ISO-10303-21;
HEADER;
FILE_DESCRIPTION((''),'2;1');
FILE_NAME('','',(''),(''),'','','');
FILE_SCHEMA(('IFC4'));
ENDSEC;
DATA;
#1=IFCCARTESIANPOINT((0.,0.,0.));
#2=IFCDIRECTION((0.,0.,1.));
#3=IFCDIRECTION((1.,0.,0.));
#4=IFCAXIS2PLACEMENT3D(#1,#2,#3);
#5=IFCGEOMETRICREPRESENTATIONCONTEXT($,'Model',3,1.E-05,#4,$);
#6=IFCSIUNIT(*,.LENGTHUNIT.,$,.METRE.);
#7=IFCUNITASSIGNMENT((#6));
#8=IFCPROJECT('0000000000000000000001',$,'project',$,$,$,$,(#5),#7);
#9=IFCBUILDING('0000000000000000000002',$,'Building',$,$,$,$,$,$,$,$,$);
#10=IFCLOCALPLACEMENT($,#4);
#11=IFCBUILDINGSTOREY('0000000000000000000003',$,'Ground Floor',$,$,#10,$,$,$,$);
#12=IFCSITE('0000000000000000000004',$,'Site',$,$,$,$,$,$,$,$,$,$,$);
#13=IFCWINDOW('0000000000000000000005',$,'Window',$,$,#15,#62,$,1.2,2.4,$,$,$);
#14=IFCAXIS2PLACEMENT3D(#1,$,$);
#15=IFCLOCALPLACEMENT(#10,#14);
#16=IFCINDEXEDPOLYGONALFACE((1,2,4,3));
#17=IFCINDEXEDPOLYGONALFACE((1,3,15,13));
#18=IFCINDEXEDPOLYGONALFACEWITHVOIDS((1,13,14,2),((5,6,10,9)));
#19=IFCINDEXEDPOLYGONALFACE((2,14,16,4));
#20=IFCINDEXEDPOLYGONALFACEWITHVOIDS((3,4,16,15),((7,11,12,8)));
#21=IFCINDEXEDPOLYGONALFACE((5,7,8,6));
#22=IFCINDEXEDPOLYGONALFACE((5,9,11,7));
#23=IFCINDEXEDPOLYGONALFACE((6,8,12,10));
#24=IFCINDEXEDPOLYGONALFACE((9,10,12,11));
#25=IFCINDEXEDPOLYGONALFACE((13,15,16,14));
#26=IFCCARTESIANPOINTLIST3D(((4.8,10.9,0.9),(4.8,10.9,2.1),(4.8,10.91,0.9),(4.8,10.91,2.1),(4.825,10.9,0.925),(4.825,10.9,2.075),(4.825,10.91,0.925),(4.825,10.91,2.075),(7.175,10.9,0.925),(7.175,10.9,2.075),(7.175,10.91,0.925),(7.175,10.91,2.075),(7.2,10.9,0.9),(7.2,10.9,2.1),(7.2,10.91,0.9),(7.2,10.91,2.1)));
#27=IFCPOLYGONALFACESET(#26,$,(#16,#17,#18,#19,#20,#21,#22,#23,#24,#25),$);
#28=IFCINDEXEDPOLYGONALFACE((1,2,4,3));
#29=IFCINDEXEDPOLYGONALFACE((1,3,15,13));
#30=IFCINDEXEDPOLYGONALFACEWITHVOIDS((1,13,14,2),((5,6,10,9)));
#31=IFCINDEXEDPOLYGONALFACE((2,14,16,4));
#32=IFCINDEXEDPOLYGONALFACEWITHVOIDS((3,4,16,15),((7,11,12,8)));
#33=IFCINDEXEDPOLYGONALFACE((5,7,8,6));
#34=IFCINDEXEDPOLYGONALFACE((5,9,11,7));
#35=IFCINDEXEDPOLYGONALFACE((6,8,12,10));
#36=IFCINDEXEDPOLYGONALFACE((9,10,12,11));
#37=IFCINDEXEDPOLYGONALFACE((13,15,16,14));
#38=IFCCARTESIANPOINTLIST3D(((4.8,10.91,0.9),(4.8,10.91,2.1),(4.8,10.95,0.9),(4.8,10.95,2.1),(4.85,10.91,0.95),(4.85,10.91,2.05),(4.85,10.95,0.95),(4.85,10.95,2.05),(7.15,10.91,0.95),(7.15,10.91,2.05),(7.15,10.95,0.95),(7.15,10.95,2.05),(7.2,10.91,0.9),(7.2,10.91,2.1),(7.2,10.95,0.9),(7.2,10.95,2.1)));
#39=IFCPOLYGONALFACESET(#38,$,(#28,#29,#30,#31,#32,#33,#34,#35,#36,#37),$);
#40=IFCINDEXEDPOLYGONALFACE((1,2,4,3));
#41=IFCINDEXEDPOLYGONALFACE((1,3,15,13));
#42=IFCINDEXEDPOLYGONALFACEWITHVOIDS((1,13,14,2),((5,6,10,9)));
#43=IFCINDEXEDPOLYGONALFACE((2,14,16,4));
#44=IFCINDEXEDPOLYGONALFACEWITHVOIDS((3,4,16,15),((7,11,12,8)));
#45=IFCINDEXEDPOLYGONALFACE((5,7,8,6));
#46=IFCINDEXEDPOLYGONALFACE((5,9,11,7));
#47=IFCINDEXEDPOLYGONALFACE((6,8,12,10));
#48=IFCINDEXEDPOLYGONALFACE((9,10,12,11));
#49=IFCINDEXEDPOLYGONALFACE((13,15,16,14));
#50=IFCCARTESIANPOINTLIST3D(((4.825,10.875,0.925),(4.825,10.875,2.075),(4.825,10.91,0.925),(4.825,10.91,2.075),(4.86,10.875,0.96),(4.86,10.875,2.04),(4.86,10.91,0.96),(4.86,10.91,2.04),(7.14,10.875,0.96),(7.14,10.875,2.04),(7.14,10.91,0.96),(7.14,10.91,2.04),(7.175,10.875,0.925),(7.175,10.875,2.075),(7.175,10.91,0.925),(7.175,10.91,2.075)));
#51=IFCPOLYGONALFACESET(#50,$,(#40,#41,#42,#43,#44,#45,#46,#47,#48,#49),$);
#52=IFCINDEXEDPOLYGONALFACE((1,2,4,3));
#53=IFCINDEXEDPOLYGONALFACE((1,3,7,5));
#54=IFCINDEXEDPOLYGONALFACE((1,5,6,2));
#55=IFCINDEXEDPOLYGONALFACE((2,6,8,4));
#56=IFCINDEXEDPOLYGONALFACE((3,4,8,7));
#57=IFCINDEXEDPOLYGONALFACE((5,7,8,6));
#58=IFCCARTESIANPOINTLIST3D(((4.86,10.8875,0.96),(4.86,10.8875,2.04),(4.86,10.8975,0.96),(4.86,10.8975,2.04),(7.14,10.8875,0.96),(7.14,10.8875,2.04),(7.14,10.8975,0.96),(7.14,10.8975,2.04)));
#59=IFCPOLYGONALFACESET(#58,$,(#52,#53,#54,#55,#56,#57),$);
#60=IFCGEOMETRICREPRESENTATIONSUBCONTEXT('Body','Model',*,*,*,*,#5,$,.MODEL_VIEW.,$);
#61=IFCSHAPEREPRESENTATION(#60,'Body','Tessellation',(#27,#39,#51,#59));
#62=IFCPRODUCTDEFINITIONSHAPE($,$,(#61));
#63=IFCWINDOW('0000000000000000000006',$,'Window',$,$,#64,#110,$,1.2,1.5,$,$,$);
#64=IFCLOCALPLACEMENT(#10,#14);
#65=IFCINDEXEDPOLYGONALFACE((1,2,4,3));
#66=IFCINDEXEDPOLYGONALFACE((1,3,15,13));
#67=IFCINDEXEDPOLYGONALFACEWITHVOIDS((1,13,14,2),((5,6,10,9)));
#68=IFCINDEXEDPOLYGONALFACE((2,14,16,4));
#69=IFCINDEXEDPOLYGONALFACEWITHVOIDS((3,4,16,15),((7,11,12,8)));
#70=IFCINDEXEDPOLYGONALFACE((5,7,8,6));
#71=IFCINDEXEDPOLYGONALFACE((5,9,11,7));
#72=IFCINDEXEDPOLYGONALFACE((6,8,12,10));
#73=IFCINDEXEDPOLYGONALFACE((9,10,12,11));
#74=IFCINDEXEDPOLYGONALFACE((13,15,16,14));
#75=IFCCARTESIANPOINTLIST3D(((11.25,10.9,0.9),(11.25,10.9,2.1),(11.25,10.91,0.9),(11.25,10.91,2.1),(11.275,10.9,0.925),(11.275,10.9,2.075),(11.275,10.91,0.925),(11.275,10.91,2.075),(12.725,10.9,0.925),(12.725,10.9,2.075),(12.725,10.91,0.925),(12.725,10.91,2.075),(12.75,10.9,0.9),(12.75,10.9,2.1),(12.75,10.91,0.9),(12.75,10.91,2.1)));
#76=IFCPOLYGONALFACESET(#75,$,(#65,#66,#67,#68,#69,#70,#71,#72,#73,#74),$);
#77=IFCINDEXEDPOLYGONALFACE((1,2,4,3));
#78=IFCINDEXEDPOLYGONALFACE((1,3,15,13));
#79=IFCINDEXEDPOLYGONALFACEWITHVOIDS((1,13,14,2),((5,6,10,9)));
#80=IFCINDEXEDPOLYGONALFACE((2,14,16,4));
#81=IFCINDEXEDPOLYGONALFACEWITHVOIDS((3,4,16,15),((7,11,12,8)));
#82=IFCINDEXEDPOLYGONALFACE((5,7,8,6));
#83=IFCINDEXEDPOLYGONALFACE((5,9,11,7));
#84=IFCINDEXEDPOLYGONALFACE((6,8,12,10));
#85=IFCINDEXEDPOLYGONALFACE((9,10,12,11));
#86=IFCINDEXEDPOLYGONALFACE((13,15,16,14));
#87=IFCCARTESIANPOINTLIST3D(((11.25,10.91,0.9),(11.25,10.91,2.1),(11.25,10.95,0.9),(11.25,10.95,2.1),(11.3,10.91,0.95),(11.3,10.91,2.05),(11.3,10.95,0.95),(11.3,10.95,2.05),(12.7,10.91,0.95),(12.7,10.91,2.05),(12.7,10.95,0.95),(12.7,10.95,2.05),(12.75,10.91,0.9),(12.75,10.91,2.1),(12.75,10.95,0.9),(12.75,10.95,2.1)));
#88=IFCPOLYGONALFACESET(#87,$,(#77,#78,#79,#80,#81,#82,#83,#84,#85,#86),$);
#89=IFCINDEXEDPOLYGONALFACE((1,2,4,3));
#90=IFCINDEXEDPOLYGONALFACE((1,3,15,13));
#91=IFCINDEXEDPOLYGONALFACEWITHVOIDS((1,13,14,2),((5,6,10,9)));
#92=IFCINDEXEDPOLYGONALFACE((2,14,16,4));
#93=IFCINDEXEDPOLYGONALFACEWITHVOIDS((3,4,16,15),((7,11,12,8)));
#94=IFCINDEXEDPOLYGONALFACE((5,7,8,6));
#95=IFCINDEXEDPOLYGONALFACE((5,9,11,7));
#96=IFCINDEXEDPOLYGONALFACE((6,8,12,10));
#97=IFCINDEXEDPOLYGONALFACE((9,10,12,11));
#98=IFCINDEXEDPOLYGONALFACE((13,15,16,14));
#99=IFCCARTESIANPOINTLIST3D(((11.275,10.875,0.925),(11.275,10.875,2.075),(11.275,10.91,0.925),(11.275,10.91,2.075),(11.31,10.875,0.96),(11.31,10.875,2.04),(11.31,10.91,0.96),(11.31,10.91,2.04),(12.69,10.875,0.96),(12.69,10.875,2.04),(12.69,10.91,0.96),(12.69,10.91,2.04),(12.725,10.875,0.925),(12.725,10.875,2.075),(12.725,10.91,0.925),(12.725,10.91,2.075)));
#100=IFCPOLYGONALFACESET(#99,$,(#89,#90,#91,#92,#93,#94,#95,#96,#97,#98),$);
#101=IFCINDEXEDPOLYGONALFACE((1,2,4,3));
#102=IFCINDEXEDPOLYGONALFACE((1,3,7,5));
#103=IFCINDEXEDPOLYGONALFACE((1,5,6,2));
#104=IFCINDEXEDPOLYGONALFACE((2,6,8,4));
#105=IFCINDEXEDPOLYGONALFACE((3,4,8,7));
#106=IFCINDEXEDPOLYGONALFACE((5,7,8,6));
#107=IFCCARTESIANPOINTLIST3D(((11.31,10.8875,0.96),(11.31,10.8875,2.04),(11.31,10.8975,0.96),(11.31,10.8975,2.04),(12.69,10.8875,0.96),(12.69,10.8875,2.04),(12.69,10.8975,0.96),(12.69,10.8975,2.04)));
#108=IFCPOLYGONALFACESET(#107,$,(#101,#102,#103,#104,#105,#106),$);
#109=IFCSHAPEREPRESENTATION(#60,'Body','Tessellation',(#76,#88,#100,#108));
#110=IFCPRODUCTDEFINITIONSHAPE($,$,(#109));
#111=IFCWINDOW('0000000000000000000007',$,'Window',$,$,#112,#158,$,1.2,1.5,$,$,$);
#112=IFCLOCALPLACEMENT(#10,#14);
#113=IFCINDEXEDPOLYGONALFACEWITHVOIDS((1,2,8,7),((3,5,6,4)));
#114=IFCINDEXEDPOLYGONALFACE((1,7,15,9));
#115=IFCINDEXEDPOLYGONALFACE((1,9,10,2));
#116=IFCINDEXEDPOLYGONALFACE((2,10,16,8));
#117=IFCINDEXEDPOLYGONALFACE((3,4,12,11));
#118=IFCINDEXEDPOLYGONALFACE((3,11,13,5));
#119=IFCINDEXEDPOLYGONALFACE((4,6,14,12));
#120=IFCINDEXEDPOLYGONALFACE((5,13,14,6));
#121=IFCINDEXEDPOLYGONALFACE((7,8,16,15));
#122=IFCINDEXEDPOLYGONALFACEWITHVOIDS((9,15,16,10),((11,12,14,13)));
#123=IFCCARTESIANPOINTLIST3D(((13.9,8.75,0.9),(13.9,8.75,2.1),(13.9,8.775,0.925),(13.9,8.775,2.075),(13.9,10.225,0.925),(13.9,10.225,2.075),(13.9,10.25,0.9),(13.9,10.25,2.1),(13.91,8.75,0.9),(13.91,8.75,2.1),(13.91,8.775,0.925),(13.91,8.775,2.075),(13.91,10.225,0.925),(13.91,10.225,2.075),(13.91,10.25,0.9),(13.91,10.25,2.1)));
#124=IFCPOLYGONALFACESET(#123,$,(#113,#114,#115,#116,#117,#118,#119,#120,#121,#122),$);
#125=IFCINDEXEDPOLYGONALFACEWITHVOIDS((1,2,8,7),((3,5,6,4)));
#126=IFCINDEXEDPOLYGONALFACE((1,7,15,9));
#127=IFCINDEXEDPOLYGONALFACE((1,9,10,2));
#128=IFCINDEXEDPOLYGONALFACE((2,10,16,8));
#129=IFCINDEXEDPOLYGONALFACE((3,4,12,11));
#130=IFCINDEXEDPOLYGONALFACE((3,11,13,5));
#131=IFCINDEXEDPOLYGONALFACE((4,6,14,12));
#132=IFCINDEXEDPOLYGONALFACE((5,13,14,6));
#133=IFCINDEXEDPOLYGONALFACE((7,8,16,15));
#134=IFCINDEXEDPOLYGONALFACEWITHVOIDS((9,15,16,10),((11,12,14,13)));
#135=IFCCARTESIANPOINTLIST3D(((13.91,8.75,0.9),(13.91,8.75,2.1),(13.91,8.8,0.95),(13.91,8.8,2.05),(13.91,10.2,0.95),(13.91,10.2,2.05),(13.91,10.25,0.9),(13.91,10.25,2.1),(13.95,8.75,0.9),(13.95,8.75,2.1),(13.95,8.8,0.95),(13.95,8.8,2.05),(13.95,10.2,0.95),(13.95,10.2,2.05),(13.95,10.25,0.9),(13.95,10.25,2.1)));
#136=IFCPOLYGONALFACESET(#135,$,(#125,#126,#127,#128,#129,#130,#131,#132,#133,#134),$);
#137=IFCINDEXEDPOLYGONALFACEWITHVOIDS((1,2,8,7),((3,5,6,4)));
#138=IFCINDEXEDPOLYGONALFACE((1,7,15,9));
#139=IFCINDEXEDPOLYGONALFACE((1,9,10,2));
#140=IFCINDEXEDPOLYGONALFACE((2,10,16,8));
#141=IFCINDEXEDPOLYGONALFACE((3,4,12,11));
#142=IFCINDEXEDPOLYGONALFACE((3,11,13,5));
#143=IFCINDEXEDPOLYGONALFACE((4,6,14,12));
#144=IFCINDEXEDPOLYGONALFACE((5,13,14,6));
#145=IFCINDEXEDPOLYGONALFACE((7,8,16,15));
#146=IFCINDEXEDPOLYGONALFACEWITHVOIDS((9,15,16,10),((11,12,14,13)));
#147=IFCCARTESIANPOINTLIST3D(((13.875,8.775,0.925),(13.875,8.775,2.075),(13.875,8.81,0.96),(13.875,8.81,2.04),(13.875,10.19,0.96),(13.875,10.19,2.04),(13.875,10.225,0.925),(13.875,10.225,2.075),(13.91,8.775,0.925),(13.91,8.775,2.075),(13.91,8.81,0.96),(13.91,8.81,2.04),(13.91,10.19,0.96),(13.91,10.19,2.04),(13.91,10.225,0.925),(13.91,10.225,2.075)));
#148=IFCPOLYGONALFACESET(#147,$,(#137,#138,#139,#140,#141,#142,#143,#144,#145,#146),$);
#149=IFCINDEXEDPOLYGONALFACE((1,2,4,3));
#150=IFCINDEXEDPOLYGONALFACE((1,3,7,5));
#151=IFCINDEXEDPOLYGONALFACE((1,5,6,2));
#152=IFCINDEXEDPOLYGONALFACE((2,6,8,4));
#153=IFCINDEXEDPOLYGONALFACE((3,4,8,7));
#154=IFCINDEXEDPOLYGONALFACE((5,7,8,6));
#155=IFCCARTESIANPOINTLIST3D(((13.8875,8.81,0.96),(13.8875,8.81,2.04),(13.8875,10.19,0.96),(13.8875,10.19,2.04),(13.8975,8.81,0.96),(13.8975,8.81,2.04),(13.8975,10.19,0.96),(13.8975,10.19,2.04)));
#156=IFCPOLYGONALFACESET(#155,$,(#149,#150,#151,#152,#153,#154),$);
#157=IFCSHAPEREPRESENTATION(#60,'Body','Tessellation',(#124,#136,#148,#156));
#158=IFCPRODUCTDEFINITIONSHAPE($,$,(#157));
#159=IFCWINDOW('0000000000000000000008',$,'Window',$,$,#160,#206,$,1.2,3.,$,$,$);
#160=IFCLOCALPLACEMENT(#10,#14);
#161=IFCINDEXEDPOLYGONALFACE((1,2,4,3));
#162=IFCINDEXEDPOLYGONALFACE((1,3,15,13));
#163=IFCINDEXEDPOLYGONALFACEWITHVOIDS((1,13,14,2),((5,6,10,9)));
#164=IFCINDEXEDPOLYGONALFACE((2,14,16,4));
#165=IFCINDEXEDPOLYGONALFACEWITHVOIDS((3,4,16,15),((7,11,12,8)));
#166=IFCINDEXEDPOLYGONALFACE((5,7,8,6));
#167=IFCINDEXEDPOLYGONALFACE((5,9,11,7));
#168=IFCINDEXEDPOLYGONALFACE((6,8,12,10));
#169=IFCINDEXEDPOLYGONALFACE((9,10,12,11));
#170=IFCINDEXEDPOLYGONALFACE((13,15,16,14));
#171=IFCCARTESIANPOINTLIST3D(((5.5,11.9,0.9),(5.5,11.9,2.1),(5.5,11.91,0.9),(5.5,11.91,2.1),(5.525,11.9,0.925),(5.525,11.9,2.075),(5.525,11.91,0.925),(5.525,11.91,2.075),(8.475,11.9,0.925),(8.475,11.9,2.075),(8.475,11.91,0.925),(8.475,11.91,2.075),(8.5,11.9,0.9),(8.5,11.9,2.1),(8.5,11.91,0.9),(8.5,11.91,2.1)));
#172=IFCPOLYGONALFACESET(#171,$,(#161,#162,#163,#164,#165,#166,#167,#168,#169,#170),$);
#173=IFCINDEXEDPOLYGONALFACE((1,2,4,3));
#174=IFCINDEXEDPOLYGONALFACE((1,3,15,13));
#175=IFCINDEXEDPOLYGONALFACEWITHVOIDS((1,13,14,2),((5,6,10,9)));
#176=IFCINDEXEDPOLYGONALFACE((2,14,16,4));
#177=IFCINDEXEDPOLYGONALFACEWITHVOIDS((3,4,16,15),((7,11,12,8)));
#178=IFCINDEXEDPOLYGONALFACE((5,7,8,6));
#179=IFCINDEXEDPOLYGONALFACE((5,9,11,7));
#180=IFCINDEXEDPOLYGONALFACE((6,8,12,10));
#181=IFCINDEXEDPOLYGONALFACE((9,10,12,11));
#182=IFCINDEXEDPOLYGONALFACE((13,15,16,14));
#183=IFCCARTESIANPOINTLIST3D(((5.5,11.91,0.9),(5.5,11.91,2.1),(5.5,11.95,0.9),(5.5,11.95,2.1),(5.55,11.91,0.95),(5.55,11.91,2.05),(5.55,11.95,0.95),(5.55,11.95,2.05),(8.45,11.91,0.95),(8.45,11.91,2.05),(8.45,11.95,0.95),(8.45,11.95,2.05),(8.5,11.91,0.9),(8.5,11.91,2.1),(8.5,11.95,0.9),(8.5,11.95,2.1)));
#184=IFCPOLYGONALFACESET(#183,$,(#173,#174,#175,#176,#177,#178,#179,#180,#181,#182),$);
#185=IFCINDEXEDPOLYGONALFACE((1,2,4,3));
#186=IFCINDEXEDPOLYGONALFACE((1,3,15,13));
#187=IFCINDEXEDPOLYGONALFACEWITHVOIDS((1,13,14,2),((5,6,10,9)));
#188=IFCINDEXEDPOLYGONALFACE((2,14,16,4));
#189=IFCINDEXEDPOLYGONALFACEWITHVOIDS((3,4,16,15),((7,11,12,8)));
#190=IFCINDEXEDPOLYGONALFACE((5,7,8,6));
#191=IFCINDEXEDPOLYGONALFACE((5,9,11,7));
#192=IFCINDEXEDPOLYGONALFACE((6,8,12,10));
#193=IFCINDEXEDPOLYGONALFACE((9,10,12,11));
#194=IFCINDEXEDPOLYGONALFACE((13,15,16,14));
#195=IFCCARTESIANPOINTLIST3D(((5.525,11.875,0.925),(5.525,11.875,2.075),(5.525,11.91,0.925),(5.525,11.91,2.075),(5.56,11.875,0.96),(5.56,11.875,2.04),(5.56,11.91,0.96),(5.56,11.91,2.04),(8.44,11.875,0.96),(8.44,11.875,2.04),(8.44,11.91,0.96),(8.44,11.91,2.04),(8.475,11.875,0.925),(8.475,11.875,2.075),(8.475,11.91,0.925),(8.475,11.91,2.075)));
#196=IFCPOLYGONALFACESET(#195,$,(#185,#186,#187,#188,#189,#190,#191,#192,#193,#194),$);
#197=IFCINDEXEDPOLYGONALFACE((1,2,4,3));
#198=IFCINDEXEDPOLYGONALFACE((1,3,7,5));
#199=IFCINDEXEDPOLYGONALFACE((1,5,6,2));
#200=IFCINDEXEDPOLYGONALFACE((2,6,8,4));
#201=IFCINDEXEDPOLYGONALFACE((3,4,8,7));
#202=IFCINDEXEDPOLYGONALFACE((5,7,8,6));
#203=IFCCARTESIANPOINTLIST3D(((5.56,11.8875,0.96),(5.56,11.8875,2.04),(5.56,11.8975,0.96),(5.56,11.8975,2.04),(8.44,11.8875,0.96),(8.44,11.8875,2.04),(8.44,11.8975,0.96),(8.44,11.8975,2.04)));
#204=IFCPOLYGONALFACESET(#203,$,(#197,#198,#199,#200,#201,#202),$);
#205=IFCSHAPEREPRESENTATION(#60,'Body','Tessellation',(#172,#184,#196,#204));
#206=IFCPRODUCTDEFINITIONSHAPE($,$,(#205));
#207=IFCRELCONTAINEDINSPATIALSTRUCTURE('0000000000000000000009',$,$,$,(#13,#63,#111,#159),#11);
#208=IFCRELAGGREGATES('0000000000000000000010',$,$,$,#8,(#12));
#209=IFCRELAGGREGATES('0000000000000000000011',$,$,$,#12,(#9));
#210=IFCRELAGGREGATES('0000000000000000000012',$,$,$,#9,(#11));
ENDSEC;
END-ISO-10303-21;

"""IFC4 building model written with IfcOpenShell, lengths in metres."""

from ifc_helpers import new_model, si_unit, frame, origin_with_axes, place, context, subcontext, project, spatial, line, indexed_curve, outline, extrude, element, save


model = new_model("IFC4")

# Units and contexts
model_context = context("Model", 3, precision=1e-05, world=origin_with_axes())
body_context = subcontext(model_context, "Body", "Model", "MODEL_VIEW")
ifc_project = project(units=[si_unit("LENGTHUNIT", "METRE")], contexts=[model_context])

# Site, building, storey
site = spatial("IfcSite", under=ifc_project, Name="Site")
building = spatial("IfcBuilding", under=site, Name="Building")
storey_placement = place(None, origin_with_axes())
storey = spatial("IfcBuildingStorey", under=building, at=storey_placement, Name="Ground Floor")

# Windows
window_1_placement = place(storey_placement, frame((7.2, 11.0, 0.9), z_axis=(0.0, 0.0, 1.0), x_axis=(-1.0, 0.0, 0.0)))
element("IfcWindow", 1, at=window_1_placement, inside=storey, Name="Window", OverallHeight=1.2, OverallWidth=2.4, context=body_context, shape_type="SweptSolid", body=[
    extrude(outline(indexed_curve([(0.0, 0.0), (2.4, 0.0), (2.4, 1.2), (0.0, 1.2)], segments=[line(1, 2, 3, 4, 1)]), holes=[indexed_curve([(0.025, 0.025), (2.375, 0.025), (2.375, 1.175), (0.025, 1.175)], segments=[line(1, 2, 3, 4, 1)])]), frame((0.0, 0.09, 0.0), z_axis=(0.0, -1.0, 0.0), x_axis=(1.0, 0.0, 0.0)), (0.0, 0.0, -1.0), 0.01),
    extrude(outline(indexed_curve([(0.0, 0.0), (2.4, 0.0), (2.4, 1.2), (0.0, 1.2)], segments=[line(1, 2, 3, 4, 1)]), holes=[indexed_curve([(0.05, 0.05), (2.35, 0.05), (2.35, 1.15), (0.05, 1.15)], segments=[line(1, 2, 3, 4, 1)])]), frame((0.0, 0.05, 0.0), z_axis=(0.0, -1.0, 0.0), x_axis=(1.0, 0.0, 0.0)), (0.0, 0.0, -1.0), 0.04),
    extrude(outline(indexed_curve([(0.0, 0.0), (2.35, 0.0), (2.35, 1.15), (0.0, 1.15)], segments=[line(1, 2, 3, 4, 1)]), holes=[indexed_curve([(0.035, 0.035), (2.315, 0.035), (2.315, 1.115), (0.035, 1.115)], segments=[line(1, 2, 3, 4, 1)])]), frame((0.025, 0.09, 0.025), z_axis=(0.0, -1.0, 0.0), x_axis=(1.0, 0.0, 0.0)), (0.0, 0.0, -1.0), 0.035),
    extrude(outline(indexed_curve([(0.035, 0.035), (2.315, 0.035), (2.315, 1.115), (0.035, 1.115)], segments=[line(1, 2, 3, 4, 1)])), frame((0.025, 0.1025, 0.025), z_axis=(0.0, -1.0, 0.0), x_axis=(1.0, 0.0, 0.0)), (0.0, 0.0, -1.0), 0.01),
])
for number, where, z_axis, x_axis, name in (
    (2, (12.75, 11.0, 0.9), (0.0, 0.0, 1.0), (-1.0, 0.0, 0.0), "Window"),
    (3, (14.0, 8.75, 0.9), (0.0, 0.0, 1.0), (0.0, 1.0, 0.0), "Window"),
):
    element("IfcWindow", number, at=place(storey_placement, frame(where, z_axis=z_axis, x_axis=x_axis)), inside=storey, Name=name, OverallHeight=1.2, OverallWidth=1.5, context=body_context, shape_type="SweptSolid", body=[
        extrude(outline(indexed_curve([(0.0, 0.0), (1.5, 0.0), (1.5, 1.2), (0.0, 1.2)], segments=[line(1, 2, 3, 4, 1)]), holes=[indexed_curve([(0.025, 0.025), (1.475, 0.025), (1.475, 1.175), (0.025, 1.175)], segments=[line(1, 2, 3, 4, 1)])]), frame((0.0, 0.09, 0.0), z_axis=(0.0, -1.0, 0.0), x_axis=(1.0, 0.0, 0.0)), (0.0, 0.0, -1.0), 0.01),
        extrude(outline(indexed_curve([(0.0, 0.0), (1.5, 0.0), (1.5, 1.2), (0.0, 1.2)], segments=[line(1, 2, 3, 4, 1)]), holes=[indexed_curve([(0.05, 0.05), (1.45, 0.05), (1.45, 1.15), (0.05, 1.15)], segments=[line(1, 2, 3, 4, 1)])]), frame((0.0, 0.05, 0.0), z_axis=(0.0, -1.0, 0.0), x_axis=(1.0, 0.0, 0.0)), (0.0, 0.0, -1.0), 0.04),
        extrude(outline(indexed_curve([(0.0, 0.0), (1.45, 0.0), (1.45, 1.15), (0.0, 1.15)], segments=[line(1, 2, 3, 4, 1)]), holes=[indexed_curve([(0.035, 0.035), (1.415, 0.035), (1.415, 1.115), (0.035, 1.115)], segments=[line(1, 2, 3, 4, 1)])]), frame((0.025, 0.09, 0.025), z_axis=(0.0, -1.0, 0.0), x_axis=(1.0, 0.0, 0.0)), (0.0, 0.0, -1.0), 0.035),
        extrude(outline(indexed_curve([(0.035, 0.035), (1.415, 0.035), (1.415, 1.115), (0.035, 1.115)], segments=[line(1, 2, 3, 4, 1)])), frame((0.025, 0.1025, 0.025), z_axis=(0.0, -1.0, 0.0), x_axis=(1.0, 0.0, 0.0)), (0.0, 0.0, -1.0), 0.01),
    ])
window_2_placement = place(storey_placement, frame((8.5, 12.0, 0.9), z_axis=(0.0, 0.0, 1.0), x_axis=(-1.0, 0.0, 0.0)))
element("IfcWindow", 4, at=window_2_placement, inside=storey, Name="Window", OverallHeight=1.2, OverallWidth=3.0, context=body_context, shape_type="SweptSolid", body=[
    extrude(outline(indexed_curve([(0.0, 0.0), (3.0, 0.0), (3.0, 1.2), (0.0, 1.2)], segments=[line(1, 2, 3, 4, 1)]), holes=[indexed_curve([(0.025, 0.025), (2.975, 0.025), (2.975, 1.175), (0.025, 1.175)], segments=[line(1, 2, 3, 4, 1)])]), frame((0.0, 0.09, 0.0), z_axis=(0.0, -1.0, 0.0), x_axis=(1.0, 0.0, 0.0)), (0.0, 0.0, -1.0), 0.01),
    extrude(outline(indexed_curve([(0.0, 0.0), (3.0, 0.0), (3.0, 1.2), (0.0, 1.2)], segments=[line(1, 2, 3, 4, 1)]), holes=[indexed_curve([(0.05, 0.05), (2.95, 0.05), (2.95, 1.15), (0.05, 1.15)], segments=[line(1, 2, 3, 4, 1)])]), frame((0.0, 0.05, 0.0), z_axis=(0.0, -1.0, 0.0), x_axis=(1.0, 0.0, 0.0)), (0.0, 0.0, -1.0), 0.04),
    extrude(outline(indexed_curve([(0.0, 0.0), (2.95, 0.0), (2.95, 1.15), (0.0, 1.15)], segments=[line(1, 2, 3, 4, 1)]), holes=[indexed_curve([(0.035, 0.035), (2.915, 0.035), (2.915, 1.115), (0.035, 1.115)], segments=[line(1, 2, 3, 4, 1)])]), frame((0.025, 0.09, 0.025), z_axis=(0.0, -1.0, 0.0), x_axis=(1.0, 0.0, 0.0)), (0.0, 0.0, -1.0), 0.035),
    extrude(outline(indexed_curve([(0.035, 0.035), (2.915, 0.035), (2.915, 1.115), (0.035, 1.115)], segments=[line(1, 2, 3, 4, 1)])), frame((0.025, 0.1025, 0.025), z_axis=(0.0, -1.0, 0.0), x_axis=(1.0, 0.0, 0.0)), (0.0, 0.0, -1.0), 0.01),
])

save(model, "model.ifc")
